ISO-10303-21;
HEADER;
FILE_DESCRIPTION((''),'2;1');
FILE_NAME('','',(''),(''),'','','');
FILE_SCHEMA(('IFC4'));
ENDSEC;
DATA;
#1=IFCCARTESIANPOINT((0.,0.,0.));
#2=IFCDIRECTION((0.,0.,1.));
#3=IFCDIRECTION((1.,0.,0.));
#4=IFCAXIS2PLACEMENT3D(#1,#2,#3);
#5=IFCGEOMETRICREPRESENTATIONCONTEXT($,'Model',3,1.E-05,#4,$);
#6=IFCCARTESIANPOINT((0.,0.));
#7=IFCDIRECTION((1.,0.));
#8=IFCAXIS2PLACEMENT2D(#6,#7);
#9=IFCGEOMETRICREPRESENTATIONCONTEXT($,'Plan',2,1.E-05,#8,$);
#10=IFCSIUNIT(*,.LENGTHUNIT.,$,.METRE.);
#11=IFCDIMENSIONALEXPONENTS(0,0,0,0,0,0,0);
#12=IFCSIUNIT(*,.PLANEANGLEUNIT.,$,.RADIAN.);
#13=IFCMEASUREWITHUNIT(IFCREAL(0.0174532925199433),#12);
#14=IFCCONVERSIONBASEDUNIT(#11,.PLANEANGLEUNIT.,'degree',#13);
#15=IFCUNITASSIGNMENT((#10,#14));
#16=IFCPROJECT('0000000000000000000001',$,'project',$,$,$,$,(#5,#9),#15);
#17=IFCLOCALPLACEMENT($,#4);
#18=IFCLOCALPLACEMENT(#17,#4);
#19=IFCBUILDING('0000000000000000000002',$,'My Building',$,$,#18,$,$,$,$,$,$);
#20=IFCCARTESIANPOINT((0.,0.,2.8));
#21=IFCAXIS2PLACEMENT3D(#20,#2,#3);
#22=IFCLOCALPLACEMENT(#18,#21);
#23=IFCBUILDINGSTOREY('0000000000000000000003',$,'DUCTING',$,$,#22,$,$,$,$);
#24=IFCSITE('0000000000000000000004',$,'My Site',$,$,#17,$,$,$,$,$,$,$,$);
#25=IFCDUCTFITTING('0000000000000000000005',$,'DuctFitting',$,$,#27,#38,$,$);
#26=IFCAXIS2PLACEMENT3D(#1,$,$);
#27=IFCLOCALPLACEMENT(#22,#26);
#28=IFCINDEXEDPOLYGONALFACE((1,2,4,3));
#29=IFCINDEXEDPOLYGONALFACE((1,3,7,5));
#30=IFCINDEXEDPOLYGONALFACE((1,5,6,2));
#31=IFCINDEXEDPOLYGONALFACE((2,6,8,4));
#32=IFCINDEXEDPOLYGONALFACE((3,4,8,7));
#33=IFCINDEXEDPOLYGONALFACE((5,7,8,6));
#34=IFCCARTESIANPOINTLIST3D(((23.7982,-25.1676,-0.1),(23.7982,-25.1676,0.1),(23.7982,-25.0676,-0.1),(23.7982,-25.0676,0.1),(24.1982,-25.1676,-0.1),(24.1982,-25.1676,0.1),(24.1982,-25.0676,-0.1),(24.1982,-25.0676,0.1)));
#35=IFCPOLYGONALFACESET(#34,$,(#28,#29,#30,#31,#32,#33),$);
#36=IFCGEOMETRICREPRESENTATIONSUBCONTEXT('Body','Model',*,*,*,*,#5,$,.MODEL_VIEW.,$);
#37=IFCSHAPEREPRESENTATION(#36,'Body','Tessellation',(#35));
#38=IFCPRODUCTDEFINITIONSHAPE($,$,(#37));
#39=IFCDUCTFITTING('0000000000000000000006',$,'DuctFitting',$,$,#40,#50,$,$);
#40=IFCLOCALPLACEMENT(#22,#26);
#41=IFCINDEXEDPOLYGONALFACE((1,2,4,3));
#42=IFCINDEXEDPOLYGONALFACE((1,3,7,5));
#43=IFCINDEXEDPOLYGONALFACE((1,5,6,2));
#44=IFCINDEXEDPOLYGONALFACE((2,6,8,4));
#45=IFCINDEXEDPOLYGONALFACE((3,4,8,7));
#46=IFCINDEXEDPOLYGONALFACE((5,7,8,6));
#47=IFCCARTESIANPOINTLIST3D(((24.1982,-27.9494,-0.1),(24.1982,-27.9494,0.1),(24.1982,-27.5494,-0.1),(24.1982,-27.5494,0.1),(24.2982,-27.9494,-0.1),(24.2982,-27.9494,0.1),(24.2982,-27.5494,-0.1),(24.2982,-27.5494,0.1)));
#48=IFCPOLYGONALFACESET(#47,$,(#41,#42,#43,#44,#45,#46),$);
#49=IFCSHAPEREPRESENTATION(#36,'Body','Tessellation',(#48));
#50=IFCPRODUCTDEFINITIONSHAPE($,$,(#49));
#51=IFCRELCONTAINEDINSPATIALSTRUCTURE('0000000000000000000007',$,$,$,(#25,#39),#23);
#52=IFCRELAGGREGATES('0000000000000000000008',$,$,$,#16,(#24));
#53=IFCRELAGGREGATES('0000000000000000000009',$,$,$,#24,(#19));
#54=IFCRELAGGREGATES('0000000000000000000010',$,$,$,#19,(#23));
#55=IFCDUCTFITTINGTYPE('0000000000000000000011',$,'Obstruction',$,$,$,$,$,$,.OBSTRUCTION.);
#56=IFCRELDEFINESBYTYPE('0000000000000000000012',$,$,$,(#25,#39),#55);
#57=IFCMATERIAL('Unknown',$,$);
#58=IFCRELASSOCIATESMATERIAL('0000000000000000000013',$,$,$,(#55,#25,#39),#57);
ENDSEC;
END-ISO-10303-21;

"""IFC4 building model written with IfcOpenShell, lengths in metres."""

from ifc_helpers import new_model, entity, si_unit, converted_unit, frame, origin_with_axes, origin_2d_with_axis, place, context, subcontext, project, spatial, rectangle, extrude, material, material_profile, profile_set, profile_usage, type_object, element, save


model = new_model("IFC4")

# Units and contexts
model_context = context("Model", 3, precision=1e-05, world=origin_with_axes())
plan_context = context("Plan", 2, precision=1e-05, world=origin_2d_with_axis())
body_context = subcontext(model_context, "Body", "Model", "MODEL_VIEW")
ifc_project = project(units=[si_unit("LENGTHUNIT", "METRE"), converted_unit("PLANEANGLEUNIT", "degree", entity("IfcReal", 0.0174532925199433), si_unit("PLANEANGLEUNIT", "RADIAN"), dimensions=[0, 0, 0, 0, 0, 0, 0])], contexts=[model_context, plan_context])

# Site, building, storey
site_placement = place(None, origin_with_axes())
site = spatial("IfcSite", under=ifc_project, at=site_placement, Name="My Site")
building_placement = place(site_placement, origin_with_axes())
building = spatial("IfcBuilding", under=site, at=building_placement, Name="My Building")
storey_placement = place(building_placement, frame((0.0, 0.0, 2.8), z_axis=(0.0, 0.0, 1.0), x_axis=(1.0, 0.0, 0.0)))
storey = spatial("IfcBuildingStorey", under=building, at=storey_placement, Name="DUCTING")

# Shared definitions
ifc_material = material(Name="Unknown")

# Duct fittings
ifc_material_profile_1 = material_profile(ifc_material, rectangle(XDim=0.4, YDim=0.2))
ifc_profile_set_1 = profile_set([ifc_material_profile_1])
duct_fitting_type_1 = type_object("IfcDuctFittingType", Name="Obstruction", PredefinedType="OBSTRUCTION", material=ifc_profile_set_1)
ifc_profile_usage_1 = profile_usage(ifc_profile_set_1, cardinal=5)
duct_fitting_1_placement = place(storey_placement, frame((23.9982, -25.0676, 0.0), z_axis=(0.0, -1.0, 0.0), x_axis=(1.0, 0.0, 0.0)))
element("IfcDuctFitting", 1, at=duct_fitting_1_placement, inside=storey, type_object=duct_fitting_type_1, material=ifc_profile_usage_1, Name="DuctFitting", context=body_context, shape_type="SweptSolid", body=[
    extrude(rectangle(XDim=0.4, YDim=0.2), origin_with_axes(), (0.0, 0.0, 1.0), 0.1),
])
ifc_profile_usage_2 = profile_usage(ifc_profile_set_1, cardinal=5)
duct_fitting_2_placement = place(storey_placement, frame((24.1982, -27.7494, 0.0), z_axis=(1.0, 0.0, 0.0), x_axis=(0.0, 1.0, 0.0)))
element("IfcDuctFitting", 2, at=duct_fitting_2_placement, inside=storey, type_object=duct_fitting_type_1, material=ifc_profile_usage_2, Name="DuctFitting", context=body_context, shape_type="SweptSolid", body=[
    extrude(rectangle(XDim=0.4, YDim=0.2), origin_with_axes(), (0.0, 0.0, 1.0), 0.1),
])

save(model, "model.ifc")
